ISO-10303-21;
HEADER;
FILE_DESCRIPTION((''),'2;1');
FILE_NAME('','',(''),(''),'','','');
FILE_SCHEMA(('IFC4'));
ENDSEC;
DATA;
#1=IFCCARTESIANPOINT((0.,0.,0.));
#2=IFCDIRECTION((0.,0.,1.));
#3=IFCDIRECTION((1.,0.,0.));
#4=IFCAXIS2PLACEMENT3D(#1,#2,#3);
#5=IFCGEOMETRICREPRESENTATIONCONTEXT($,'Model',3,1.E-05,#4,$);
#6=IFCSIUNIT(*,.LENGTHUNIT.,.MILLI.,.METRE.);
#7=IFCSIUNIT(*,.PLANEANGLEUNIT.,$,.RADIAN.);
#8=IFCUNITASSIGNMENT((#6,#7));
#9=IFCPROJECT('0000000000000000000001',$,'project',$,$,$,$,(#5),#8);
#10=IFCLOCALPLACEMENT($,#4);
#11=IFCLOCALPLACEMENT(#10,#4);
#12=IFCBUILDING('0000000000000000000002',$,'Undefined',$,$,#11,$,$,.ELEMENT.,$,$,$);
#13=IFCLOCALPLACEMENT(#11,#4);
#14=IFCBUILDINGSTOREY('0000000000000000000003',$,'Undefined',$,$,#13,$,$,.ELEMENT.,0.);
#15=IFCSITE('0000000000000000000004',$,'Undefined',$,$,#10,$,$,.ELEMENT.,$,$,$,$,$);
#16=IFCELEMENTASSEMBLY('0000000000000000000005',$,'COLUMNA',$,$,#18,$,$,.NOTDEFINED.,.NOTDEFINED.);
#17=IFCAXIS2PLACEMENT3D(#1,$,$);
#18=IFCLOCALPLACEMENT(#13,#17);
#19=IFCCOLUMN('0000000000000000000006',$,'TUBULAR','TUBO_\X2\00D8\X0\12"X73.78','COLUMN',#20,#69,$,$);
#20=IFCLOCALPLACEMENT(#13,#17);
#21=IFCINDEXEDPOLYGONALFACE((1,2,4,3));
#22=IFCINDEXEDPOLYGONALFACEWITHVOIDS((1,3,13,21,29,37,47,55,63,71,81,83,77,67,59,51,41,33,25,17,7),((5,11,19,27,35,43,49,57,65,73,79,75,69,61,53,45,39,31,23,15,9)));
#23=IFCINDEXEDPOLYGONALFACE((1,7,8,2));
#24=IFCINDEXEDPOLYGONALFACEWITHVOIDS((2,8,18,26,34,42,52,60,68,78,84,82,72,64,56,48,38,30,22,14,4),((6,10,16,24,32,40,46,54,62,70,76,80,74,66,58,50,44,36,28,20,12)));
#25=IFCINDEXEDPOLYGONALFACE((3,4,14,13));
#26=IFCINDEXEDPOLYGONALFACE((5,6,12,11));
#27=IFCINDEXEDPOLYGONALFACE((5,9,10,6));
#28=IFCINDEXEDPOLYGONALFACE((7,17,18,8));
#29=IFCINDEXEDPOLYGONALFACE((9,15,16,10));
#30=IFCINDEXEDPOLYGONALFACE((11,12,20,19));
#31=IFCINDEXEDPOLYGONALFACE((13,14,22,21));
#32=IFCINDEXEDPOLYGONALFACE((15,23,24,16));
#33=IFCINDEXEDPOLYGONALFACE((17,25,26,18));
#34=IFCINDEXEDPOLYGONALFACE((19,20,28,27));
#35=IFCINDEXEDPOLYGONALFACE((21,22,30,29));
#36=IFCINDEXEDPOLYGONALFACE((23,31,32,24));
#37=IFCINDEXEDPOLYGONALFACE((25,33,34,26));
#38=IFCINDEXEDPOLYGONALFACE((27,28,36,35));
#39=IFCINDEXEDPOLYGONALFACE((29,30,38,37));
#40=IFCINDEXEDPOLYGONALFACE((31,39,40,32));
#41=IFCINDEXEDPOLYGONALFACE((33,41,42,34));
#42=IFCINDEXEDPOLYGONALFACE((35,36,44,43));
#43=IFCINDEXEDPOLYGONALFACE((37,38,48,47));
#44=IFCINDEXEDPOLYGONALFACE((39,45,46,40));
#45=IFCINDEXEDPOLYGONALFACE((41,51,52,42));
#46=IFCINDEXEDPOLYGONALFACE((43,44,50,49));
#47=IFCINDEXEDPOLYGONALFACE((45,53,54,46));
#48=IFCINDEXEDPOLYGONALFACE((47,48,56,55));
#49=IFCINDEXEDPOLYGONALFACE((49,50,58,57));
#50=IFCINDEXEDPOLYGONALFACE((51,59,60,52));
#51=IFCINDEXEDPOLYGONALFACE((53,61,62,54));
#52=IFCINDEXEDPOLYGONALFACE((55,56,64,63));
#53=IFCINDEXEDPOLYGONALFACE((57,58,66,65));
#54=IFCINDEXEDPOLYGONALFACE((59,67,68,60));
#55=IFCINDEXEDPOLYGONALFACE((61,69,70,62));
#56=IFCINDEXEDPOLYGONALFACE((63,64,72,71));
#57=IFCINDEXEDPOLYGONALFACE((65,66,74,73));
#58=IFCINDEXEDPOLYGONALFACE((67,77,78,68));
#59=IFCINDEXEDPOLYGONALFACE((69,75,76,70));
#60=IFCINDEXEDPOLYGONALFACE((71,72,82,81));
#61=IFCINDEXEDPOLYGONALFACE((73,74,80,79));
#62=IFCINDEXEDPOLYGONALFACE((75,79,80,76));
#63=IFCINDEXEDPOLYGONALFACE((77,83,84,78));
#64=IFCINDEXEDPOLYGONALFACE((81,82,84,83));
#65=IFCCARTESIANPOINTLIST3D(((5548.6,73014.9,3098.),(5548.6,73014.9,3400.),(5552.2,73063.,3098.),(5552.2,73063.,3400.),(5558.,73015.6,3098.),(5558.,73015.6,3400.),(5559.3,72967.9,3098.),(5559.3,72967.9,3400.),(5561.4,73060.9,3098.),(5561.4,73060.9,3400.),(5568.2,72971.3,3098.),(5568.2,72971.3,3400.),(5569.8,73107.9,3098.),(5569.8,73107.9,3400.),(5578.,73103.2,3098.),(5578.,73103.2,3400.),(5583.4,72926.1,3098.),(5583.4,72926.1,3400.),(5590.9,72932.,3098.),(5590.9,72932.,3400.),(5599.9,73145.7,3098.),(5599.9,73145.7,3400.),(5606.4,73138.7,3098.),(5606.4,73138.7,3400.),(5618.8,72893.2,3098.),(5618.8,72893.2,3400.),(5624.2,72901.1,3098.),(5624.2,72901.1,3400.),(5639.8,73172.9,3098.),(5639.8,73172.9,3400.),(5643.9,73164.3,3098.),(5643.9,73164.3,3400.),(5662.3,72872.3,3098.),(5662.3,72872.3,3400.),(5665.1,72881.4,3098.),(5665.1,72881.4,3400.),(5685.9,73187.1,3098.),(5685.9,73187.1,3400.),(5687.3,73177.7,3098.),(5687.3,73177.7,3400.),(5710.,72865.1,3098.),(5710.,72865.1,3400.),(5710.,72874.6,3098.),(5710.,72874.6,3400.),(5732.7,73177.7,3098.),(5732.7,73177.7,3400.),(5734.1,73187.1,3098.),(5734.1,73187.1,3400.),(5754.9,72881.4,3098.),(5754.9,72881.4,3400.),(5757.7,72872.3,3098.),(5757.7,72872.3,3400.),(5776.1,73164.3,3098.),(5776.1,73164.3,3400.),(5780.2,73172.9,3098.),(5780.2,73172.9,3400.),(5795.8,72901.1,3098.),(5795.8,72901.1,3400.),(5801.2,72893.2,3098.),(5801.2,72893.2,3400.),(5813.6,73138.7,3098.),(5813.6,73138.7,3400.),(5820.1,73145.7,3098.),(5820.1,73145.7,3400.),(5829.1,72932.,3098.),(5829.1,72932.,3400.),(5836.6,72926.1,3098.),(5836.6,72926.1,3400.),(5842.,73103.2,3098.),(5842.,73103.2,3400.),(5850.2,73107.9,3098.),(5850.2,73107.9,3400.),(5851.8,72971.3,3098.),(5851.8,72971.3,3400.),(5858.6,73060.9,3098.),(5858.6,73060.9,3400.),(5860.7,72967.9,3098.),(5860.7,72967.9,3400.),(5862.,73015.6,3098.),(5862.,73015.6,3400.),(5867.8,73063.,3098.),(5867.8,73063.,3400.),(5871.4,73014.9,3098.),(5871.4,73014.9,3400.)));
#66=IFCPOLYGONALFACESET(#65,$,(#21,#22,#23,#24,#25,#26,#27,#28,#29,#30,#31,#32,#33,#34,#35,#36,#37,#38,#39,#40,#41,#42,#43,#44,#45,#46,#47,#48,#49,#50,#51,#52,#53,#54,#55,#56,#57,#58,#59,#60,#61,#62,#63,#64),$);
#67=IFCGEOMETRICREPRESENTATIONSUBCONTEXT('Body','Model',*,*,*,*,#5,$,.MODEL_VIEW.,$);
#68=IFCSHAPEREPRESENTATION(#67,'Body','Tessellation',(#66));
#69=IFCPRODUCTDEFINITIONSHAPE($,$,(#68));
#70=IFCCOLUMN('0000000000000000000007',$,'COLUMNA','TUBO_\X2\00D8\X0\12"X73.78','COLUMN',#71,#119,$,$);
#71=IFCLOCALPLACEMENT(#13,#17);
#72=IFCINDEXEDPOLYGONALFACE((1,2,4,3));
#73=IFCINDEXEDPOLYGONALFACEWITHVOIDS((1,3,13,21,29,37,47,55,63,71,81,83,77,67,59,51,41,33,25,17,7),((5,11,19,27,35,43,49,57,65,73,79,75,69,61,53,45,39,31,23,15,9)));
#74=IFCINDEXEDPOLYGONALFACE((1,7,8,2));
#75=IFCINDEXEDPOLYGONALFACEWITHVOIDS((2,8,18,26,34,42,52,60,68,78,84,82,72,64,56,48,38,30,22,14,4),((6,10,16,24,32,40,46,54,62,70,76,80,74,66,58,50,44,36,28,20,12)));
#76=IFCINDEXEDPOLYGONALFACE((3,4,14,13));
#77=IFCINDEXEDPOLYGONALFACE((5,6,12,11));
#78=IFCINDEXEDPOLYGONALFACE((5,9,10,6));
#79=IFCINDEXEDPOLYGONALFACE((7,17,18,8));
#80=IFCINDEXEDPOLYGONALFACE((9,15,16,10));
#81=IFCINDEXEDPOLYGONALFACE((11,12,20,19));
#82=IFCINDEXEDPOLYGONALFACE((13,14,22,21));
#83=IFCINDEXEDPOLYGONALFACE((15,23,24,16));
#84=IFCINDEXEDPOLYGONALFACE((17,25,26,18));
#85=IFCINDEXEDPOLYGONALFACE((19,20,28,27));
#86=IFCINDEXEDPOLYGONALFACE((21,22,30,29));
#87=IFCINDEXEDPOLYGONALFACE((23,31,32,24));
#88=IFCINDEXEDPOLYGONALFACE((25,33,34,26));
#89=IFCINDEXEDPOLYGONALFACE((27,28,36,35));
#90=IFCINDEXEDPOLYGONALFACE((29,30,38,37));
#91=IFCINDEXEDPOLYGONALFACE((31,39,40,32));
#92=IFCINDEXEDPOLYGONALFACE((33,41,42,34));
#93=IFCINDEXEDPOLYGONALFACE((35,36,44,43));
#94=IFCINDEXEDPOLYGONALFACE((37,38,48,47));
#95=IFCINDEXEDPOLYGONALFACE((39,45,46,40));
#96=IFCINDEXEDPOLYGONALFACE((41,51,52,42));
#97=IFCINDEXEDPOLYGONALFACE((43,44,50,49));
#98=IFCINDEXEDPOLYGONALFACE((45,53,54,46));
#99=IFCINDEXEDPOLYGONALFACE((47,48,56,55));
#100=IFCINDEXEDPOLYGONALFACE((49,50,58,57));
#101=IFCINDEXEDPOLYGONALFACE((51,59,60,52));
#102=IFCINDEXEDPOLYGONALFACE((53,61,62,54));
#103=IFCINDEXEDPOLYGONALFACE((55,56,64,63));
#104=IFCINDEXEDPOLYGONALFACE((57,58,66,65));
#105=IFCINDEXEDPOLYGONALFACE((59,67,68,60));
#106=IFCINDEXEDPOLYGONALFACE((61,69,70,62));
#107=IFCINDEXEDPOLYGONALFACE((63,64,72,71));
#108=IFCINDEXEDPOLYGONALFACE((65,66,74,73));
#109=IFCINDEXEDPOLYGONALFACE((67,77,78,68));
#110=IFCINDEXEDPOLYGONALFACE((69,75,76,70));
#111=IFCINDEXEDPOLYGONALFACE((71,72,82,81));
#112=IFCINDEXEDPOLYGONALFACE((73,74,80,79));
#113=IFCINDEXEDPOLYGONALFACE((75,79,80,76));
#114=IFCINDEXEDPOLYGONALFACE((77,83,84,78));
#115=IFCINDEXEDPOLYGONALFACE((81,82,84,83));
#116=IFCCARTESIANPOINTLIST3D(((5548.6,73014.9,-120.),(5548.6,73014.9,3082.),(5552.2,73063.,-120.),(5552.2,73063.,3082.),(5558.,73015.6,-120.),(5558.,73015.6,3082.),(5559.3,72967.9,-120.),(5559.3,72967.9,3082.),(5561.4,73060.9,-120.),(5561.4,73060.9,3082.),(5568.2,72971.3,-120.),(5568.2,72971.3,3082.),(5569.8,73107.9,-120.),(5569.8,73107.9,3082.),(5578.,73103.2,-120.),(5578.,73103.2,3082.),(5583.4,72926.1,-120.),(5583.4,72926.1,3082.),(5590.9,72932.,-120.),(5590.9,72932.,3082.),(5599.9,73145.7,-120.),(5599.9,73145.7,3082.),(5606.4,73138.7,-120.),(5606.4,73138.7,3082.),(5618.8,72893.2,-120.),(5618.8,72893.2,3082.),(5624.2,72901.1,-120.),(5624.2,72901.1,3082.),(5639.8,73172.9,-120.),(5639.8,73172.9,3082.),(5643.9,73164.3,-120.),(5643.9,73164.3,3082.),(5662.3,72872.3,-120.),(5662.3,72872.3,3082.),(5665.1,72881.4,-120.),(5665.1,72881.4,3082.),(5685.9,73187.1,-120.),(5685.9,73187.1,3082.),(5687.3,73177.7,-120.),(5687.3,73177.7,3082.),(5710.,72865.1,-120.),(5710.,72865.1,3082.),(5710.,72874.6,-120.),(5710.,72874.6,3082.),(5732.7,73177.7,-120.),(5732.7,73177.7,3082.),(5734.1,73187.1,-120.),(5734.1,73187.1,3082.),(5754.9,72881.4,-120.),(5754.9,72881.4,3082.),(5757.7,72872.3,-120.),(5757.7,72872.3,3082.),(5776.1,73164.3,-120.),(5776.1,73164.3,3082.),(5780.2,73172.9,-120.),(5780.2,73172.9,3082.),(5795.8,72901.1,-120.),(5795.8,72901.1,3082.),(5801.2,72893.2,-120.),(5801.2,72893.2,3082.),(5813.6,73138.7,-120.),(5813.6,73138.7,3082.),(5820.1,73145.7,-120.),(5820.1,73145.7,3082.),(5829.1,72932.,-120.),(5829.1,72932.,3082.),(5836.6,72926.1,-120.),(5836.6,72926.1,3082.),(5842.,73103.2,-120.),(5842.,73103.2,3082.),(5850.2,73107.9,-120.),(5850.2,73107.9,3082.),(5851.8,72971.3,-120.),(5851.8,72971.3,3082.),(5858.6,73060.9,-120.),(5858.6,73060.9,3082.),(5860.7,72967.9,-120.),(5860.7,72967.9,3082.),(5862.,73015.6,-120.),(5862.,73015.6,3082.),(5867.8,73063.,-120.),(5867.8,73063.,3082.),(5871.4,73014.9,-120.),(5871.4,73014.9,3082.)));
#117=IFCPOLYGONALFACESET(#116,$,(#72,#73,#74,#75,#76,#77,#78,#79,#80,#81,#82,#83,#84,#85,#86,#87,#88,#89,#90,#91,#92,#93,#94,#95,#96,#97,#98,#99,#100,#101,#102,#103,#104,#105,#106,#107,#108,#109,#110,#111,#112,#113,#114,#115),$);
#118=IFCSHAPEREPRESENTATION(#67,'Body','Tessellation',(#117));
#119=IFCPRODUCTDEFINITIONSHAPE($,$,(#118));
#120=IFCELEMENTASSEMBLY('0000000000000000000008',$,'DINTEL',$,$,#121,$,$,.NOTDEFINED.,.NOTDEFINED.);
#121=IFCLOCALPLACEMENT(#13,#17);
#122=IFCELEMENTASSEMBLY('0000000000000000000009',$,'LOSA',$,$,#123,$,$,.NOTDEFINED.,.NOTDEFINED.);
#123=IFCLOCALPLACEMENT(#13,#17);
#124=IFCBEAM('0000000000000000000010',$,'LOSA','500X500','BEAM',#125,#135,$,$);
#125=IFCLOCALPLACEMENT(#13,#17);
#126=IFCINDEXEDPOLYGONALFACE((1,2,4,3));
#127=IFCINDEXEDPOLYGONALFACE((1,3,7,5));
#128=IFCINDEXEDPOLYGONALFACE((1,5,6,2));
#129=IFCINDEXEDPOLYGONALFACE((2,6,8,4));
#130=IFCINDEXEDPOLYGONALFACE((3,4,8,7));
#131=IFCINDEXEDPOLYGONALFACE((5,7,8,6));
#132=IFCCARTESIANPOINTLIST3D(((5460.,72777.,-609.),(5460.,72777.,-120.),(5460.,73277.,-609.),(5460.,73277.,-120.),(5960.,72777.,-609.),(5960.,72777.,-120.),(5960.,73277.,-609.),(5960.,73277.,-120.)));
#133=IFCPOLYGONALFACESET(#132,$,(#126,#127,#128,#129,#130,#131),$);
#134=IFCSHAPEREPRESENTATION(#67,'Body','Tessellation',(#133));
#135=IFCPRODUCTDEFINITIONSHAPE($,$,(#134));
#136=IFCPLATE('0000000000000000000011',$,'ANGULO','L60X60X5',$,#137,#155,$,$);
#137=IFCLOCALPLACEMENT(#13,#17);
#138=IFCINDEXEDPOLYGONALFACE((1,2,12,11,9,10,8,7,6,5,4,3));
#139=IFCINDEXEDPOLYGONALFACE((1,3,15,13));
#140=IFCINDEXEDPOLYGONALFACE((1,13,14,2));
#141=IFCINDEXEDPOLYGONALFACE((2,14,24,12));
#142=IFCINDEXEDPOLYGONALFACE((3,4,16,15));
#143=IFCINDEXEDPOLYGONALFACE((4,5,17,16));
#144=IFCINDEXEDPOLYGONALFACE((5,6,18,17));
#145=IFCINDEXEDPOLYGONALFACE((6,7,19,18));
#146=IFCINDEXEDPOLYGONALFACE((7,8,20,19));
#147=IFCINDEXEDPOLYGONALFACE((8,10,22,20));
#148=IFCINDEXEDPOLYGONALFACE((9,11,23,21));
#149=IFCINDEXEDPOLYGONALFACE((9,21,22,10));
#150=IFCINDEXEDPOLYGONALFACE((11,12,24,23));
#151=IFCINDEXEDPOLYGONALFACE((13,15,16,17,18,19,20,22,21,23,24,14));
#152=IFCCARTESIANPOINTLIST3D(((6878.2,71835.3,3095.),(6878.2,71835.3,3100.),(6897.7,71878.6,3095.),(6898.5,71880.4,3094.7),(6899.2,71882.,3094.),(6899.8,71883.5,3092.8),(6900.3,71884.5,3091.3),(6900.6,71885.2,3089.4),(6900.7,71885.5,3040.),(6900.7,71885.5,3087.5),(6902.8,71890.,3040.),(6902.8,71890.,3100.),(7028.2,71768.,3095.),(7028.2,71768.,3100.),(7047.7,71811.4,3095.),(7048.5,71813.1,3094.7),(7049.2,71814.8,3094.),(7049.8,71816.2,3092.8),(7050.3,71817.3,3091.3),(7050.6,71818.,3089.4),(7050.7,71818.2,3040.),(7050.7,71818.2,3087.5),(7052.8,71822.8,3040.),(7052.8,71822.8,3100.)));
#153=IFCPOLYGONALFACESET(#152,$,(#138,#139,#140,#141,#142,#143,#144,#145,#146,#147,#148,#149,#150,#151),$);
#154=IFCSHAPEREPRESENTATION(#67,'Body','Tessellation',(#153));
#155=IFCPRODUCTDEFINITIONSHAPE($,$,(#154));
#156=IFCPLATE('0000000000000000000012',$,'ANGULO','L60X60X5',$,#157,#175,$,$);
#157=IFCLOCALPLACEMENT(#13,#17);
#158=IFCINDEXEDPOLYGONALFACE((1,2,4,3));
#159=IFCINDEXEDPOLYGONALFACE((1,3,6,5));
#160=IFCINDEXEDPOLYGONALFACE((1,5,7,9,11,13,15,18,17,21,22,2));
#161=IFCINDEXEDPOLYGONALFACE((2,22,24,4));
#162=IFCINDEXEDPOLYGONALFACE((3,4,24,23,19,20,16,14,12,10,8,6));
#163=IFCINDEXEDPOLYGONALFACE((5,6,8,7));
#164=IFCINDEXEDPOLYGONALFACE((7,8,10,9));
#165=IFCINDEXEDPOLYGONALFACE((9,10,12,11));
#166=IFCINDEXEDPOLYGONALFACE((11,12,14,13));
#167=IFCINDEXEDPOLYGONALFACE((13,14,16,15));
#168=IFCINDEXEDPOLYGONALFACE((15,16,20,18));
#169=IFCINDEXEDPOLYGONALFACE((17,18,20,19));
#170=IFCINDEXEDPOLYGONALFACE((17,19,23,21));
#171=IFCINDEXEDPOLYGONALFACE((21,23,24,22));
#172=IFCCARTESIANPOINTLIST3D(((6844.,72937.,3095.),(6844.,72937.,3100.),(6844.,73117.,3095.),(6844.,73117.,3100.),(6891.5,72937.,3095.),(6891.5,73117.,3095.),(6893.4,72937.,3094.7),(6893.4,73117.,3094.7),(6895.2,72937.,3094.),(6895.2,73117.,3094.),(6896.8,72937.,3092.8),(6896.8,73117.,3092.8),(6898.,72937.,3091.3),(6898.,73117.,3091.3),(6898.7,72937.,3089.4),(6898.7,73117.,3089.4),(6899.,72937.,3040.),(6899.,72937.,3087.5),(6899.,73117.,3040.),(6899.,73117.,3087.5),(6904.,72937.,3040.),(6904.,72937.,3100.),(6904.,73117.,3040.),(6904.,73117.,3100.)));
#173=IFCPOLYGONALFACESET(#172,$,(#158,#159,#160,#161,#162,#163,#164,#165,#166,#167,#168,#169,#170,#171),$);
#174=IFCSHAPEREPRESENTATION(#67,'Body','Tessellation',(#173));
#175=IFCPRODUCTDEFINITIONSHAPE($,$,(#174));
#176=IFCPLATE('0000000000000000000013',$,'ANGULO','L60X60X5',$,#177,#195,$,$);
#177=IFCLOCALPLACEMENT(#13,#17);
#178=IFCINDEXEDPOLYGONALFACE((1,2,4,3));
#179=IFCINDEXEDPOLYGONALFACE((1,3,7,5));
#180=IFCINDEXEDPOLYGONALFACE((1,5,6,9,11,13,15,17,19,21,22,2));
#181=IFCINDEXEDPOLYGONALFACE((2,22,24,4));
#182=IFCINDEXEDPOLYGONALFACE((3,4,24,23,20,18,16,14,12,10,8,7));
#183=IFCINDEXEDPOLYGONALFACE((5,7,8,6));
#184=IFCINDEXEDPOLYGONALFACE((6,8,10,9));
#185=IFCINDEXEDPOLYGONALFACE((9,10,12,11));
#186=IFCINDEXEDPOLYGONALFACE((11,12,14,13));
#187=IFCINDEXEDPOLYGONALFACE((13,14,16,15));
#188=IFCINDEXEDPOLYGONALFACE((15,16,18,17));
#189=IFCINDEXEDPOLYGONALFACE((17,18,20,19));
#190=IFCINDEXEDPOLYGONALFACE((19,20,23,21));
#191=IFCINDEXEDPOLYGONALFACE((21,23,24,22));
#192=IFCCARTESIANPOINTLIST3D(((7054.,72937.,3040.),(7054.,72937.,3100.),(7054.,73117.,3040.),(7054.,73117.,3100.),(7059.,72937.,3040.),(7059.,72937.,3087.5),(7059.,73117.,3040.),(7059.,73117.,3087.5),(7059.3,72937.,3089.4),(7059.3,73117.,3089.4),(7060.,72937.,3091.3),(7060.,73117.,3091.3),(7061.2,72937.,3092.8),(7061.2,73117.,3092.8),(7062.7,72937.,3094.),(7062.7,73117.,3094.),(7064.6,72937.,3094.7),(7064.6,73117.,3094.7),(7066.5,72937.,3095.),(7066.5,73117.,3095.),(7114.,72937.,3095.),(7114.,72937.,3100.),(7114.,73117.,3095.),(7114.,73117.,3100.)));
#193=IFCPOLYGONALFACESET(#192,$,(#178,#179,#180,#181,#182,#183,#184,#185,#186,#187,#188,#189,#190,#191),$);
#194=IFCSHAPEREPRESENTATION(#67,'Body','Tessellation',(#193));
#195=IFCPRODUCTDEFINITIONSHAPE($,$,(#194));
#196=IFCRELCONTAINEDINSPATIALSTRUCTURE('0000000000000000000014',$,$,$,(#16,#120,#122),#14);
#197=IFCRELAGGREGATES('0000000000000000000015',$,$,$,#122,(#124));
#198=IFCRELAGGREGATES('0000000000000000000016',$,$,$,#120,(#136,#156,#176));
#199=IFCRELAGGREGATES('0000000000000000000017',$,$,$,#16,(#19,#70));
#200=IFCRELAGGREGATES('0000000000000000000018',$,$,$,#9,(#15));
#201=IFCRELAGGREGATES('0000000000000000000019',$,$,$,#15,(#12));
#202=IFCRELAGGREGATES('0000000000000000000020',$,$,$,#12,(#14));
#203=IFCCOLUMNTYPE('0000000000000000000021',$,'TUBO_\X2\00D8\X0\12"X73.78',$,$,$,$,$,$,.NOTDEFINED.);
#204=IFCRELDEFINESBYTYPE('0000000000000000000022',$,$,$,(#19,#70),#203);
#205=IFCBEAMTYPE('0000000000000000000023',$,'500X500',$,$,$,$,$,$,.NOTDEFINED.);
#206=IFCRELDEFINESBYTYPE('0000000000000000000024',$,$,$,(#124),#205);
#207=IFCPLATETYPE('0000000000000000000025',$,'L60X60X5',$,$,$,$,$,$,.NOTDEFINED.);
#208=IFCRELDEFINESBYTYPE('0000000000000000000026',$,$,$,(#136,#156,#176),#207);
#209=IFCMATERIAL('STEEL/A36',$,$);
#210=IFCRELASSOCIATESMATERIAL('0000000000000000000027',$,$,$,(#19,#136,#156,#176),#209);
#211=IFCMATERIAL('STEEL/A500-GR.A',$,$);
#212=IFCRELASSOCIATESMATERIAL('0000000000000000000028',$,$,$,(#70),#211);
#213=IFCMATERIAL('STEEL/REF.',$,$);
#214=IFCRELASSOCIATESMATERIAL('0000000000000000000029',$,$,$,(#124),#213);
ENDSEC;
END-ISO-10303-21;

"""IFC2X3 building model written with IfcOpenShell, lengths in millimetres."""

from ifc_helpers import new_model, si_unit, frame, origin_with_axes, origin_2d_with_axis, place, context, subcontext, project, spatial, rectangle, hollow_circle, l_section, extrude, material, type_object, element, aggregate, save


model = new_model("IFC2X3")

# Units and contexts
model_context = context("Model", 3, precision=1e-05, world=origin_with_axes())
body_context = subcontext(model_context, "Body", "Model", "MODEL_VIEW")
ifc_project = project(units=[si_unit("LENGTHUNIT", "METRE", prefix="MILLI"), si_unit("PLANEANGLEUNIT", "RADIAN")], contexts=[model_context])

# Site, building, storey
site_placement = place(None, origin_with_axes())
site = spatial("IfcSite", under=ifc_project, at=site_placement, Name="Undefined", CompositionType="ELEMENT")
building_placement = place(site_placement, origin_with_axes())
building = spatial("IfcBuilding", under=site, at=building_placement, Name="Undefined", CompositionType="ELEMENT")
storey_placement = place(building_placement, origin_with_axes())
storey = spatial("IfcBuildingStorey", under=building, at=storey_placement, Name="Undefined", CompositionType="ELEMENT", Elevation=0.0)

# Element assembly, columns
assembly_1_placement = place(storey_placement, origin_with_axes())
assembly_1 = element("IfcElementAssembly", 1, at=assembly_1_placement, inside=storey, Name="COLUMNA", AssemblyPlace="NOTDEFINED", PredefinedType="NOTDEFINED")
ifc_material_1 = material(Name="STEEL/A36")
column_type = type_object("IfcColumnType", Name="TUBO_Ø12\"X73.78", PredefinedType="NOTDEFINED")
column_1_placement = place(assembly_1_placement, frame((5710.0, 73027.0, 3098.0), z_axis=(0.0, 0.0, 1.0), x_axis=(-1.0, 0.0, 0.0)))
column_1 = element("IfcColumn", 2, at=column_1_placement, type_object=column_type, material=ifc_material_1, Name="TUBULAR", Description="TUBO_Ø12\"X73.78", ObjectType="COLUMN", context=body_context, shape_type="SweptSolid", body=[
    extrude(hollow_circle(Radius=161.9, WallThickness=9.5, at=origin_2d_with_axis()), frame((0.0, 0.0, 302.0), z_axis=(0.0, 0.0, -1.0), x_axis=(0.0, 1.0, 0.0)), (0.0, 0.0, 1.0), 302.0),
])
ifc_material_2 = material(Name="STEEL/A500-GR.A")
column_2_placement = place(assembly_1_placement, frame((5710.0, 73027.0, -120.0), z_axis=(0.0, 0.0, 1.0), x_axis=(-1.0, 0.0, 0.0)))
column_2 = element("IfcColumn", 3, at=column_2_placement, type_object=column_type, material=ifc_material_2, Name="COLUMNA", Description="TUBO_Ø12\"X73.78", ObjectType="COLUMN", context=body_context, shape_type="SweptSolid", body=[
    extrude(hollow_circle(Radius=161.9, WallThickness=9.5, at=origin_2d_with_axis()), frame((0.0, 0.0, 3202.0), z_axis=(0.0, 0.0, -1.0), x_axis=(0.0, 1.0, 0.0)), (0.0, 0.0, 1.0), 3202.0),
])

# Element assemblies, beam
assembly_2_placement = place(storey_placement, origin_with_axes())
assembly_2 = element("IfcElementAssembly", 4, at=assembly_2_placement, inside=storey, Name="DINTEL", AssemblyPlace="NOTDEFINED", PredefinedType="NOTDEFINED")
assembly_3_placement = place(storey_placement, origin_with_axes())
assembly_3 = element("IfcElementAssembly", 5, at=assembly_3_placement, inside=storey, Name="LOSA", AssemblyPlace="NOTDEFINED", PredefinedType="NOTDEFINED")
ifc_material_3 = material(Name="STEEL/REF.")
beam_type_1 = type_object("IfcBeamType", Name="500X500", PredefinedType="NOTDEFINED")
beam_1_placement = place(assembly_3_placement, frame((5710.0, 73027.0, -120.0), z_axis=(1.0, 0.0, 0.0), x_axis=(0.0, 0.0, -1.0)))
beam_1 = element("IfcBeam", 6, at=beam_1_placement, type_object=beam_type_1, material=ifc_material_3, Name="LOSA", Description="500X500", ObjectType="BEAM", context=body_context, shape_type="SweptSolid", body=[
    extrude(rectangle(XDim=500.0, YDim=500.0, at=origin_2d_with_axis()), frame((489.0, 0.0, 0.0), z_axis=(-1.0, 0.0, 0.0), x_axis=(0.0, -1.0, 0.0)), (0.0, 0.0, 1.0), 489.0),
])
aggregate(assembly_3, [beam_1])

# Plates
plate_type_1 = type_object("IfcPlateType", Name="L60X60X5", PredefinedType="NOTDEFINED")
plate_1_placement = place(assembly_2_placement, frame((7040.5, 71795.4, 3070.0), z_axis=(0.0, 0.0, -1.0), x_axis=(-0.912463, 0.409159, 0.0)))
plate_1 = element("IfcPlate", 7, at=plate_1_placement, type_object=plate_type_1, material=ifc_material_1, Name="ANGULO", Description="L60X60X5", context=body_context, shape_type="SweptSolid", body=[
    extrude(l_section(Depth=60.0, Width=60.0, Thickness=5.0, FilletRadius=7.5, at=origin_2d_with_axis()), frame((164.4, 0.0, 0.0), z_axis=(-1.0, 0.0, 0.0), x_axis=(0.0, -1.0, 0.0)), (0.0, 0.0, 1.0), 164.4),
])
plate_2_placement = place(assembly_2_placement, frame((6874.0, 72937.0, 3070.0), z_axis=(0.0, 0.0, -1.0), x_axis=(0.0, 1.0, 0.0)))
plate_2 = element("IfcPlate", 8, at=plate_2_placement, type_object=plate_type_1, material=ifc_material_1, Name="ANGULO", Description="L60X60X5", context=body_context, shape_type="SweptSolid", body=[
    extrude(l_section(Depth=60.0, Width=60.0, Thickness=5.0, FilletRadius=7.5, at=origin_2d_with_axis()), frame((180.0, 0.0, 0.0), z_axis=(-1.0, 0.0, 0.0), x_axis=(0.0, -1.0, 0.0)), (0.0, 0.0, 1.0), 180.0),
])
plate_3_placement = place(assembly_2_placement, frame((7084.0, 73117.0, 3070.0), z_axis=(0.0, 0.0, -1.0), x_axis=(0.0, -1.0, 0.0)))
plate_3 = element("IfcPlate", 9, at=plate_3_placement, type_object=plate_type_1, material=ifc_material_1, Name="ANGULO", Description="L60X60X5", context=body_context, shape_type="SweptSolid", body=[
    extrude(l_section(Depth=60.0, Width=60.0, Thickness=5.0, FilletRadius=7.5, at=origin_2d_with_axis()), frame((180.0, 0.0, 0.0), z_axis=(-1.0, 0.0, 0.0), x_axis=(0.0, -1.0, 0.0)), (0.0, 0.0, 1.0), 180.0),
])
aggregate(assembly_2, [plate_1, plate_2, plate_3])

aggregate(assembly_1, [column_1, column_2])

save(model, "model.ifc")
